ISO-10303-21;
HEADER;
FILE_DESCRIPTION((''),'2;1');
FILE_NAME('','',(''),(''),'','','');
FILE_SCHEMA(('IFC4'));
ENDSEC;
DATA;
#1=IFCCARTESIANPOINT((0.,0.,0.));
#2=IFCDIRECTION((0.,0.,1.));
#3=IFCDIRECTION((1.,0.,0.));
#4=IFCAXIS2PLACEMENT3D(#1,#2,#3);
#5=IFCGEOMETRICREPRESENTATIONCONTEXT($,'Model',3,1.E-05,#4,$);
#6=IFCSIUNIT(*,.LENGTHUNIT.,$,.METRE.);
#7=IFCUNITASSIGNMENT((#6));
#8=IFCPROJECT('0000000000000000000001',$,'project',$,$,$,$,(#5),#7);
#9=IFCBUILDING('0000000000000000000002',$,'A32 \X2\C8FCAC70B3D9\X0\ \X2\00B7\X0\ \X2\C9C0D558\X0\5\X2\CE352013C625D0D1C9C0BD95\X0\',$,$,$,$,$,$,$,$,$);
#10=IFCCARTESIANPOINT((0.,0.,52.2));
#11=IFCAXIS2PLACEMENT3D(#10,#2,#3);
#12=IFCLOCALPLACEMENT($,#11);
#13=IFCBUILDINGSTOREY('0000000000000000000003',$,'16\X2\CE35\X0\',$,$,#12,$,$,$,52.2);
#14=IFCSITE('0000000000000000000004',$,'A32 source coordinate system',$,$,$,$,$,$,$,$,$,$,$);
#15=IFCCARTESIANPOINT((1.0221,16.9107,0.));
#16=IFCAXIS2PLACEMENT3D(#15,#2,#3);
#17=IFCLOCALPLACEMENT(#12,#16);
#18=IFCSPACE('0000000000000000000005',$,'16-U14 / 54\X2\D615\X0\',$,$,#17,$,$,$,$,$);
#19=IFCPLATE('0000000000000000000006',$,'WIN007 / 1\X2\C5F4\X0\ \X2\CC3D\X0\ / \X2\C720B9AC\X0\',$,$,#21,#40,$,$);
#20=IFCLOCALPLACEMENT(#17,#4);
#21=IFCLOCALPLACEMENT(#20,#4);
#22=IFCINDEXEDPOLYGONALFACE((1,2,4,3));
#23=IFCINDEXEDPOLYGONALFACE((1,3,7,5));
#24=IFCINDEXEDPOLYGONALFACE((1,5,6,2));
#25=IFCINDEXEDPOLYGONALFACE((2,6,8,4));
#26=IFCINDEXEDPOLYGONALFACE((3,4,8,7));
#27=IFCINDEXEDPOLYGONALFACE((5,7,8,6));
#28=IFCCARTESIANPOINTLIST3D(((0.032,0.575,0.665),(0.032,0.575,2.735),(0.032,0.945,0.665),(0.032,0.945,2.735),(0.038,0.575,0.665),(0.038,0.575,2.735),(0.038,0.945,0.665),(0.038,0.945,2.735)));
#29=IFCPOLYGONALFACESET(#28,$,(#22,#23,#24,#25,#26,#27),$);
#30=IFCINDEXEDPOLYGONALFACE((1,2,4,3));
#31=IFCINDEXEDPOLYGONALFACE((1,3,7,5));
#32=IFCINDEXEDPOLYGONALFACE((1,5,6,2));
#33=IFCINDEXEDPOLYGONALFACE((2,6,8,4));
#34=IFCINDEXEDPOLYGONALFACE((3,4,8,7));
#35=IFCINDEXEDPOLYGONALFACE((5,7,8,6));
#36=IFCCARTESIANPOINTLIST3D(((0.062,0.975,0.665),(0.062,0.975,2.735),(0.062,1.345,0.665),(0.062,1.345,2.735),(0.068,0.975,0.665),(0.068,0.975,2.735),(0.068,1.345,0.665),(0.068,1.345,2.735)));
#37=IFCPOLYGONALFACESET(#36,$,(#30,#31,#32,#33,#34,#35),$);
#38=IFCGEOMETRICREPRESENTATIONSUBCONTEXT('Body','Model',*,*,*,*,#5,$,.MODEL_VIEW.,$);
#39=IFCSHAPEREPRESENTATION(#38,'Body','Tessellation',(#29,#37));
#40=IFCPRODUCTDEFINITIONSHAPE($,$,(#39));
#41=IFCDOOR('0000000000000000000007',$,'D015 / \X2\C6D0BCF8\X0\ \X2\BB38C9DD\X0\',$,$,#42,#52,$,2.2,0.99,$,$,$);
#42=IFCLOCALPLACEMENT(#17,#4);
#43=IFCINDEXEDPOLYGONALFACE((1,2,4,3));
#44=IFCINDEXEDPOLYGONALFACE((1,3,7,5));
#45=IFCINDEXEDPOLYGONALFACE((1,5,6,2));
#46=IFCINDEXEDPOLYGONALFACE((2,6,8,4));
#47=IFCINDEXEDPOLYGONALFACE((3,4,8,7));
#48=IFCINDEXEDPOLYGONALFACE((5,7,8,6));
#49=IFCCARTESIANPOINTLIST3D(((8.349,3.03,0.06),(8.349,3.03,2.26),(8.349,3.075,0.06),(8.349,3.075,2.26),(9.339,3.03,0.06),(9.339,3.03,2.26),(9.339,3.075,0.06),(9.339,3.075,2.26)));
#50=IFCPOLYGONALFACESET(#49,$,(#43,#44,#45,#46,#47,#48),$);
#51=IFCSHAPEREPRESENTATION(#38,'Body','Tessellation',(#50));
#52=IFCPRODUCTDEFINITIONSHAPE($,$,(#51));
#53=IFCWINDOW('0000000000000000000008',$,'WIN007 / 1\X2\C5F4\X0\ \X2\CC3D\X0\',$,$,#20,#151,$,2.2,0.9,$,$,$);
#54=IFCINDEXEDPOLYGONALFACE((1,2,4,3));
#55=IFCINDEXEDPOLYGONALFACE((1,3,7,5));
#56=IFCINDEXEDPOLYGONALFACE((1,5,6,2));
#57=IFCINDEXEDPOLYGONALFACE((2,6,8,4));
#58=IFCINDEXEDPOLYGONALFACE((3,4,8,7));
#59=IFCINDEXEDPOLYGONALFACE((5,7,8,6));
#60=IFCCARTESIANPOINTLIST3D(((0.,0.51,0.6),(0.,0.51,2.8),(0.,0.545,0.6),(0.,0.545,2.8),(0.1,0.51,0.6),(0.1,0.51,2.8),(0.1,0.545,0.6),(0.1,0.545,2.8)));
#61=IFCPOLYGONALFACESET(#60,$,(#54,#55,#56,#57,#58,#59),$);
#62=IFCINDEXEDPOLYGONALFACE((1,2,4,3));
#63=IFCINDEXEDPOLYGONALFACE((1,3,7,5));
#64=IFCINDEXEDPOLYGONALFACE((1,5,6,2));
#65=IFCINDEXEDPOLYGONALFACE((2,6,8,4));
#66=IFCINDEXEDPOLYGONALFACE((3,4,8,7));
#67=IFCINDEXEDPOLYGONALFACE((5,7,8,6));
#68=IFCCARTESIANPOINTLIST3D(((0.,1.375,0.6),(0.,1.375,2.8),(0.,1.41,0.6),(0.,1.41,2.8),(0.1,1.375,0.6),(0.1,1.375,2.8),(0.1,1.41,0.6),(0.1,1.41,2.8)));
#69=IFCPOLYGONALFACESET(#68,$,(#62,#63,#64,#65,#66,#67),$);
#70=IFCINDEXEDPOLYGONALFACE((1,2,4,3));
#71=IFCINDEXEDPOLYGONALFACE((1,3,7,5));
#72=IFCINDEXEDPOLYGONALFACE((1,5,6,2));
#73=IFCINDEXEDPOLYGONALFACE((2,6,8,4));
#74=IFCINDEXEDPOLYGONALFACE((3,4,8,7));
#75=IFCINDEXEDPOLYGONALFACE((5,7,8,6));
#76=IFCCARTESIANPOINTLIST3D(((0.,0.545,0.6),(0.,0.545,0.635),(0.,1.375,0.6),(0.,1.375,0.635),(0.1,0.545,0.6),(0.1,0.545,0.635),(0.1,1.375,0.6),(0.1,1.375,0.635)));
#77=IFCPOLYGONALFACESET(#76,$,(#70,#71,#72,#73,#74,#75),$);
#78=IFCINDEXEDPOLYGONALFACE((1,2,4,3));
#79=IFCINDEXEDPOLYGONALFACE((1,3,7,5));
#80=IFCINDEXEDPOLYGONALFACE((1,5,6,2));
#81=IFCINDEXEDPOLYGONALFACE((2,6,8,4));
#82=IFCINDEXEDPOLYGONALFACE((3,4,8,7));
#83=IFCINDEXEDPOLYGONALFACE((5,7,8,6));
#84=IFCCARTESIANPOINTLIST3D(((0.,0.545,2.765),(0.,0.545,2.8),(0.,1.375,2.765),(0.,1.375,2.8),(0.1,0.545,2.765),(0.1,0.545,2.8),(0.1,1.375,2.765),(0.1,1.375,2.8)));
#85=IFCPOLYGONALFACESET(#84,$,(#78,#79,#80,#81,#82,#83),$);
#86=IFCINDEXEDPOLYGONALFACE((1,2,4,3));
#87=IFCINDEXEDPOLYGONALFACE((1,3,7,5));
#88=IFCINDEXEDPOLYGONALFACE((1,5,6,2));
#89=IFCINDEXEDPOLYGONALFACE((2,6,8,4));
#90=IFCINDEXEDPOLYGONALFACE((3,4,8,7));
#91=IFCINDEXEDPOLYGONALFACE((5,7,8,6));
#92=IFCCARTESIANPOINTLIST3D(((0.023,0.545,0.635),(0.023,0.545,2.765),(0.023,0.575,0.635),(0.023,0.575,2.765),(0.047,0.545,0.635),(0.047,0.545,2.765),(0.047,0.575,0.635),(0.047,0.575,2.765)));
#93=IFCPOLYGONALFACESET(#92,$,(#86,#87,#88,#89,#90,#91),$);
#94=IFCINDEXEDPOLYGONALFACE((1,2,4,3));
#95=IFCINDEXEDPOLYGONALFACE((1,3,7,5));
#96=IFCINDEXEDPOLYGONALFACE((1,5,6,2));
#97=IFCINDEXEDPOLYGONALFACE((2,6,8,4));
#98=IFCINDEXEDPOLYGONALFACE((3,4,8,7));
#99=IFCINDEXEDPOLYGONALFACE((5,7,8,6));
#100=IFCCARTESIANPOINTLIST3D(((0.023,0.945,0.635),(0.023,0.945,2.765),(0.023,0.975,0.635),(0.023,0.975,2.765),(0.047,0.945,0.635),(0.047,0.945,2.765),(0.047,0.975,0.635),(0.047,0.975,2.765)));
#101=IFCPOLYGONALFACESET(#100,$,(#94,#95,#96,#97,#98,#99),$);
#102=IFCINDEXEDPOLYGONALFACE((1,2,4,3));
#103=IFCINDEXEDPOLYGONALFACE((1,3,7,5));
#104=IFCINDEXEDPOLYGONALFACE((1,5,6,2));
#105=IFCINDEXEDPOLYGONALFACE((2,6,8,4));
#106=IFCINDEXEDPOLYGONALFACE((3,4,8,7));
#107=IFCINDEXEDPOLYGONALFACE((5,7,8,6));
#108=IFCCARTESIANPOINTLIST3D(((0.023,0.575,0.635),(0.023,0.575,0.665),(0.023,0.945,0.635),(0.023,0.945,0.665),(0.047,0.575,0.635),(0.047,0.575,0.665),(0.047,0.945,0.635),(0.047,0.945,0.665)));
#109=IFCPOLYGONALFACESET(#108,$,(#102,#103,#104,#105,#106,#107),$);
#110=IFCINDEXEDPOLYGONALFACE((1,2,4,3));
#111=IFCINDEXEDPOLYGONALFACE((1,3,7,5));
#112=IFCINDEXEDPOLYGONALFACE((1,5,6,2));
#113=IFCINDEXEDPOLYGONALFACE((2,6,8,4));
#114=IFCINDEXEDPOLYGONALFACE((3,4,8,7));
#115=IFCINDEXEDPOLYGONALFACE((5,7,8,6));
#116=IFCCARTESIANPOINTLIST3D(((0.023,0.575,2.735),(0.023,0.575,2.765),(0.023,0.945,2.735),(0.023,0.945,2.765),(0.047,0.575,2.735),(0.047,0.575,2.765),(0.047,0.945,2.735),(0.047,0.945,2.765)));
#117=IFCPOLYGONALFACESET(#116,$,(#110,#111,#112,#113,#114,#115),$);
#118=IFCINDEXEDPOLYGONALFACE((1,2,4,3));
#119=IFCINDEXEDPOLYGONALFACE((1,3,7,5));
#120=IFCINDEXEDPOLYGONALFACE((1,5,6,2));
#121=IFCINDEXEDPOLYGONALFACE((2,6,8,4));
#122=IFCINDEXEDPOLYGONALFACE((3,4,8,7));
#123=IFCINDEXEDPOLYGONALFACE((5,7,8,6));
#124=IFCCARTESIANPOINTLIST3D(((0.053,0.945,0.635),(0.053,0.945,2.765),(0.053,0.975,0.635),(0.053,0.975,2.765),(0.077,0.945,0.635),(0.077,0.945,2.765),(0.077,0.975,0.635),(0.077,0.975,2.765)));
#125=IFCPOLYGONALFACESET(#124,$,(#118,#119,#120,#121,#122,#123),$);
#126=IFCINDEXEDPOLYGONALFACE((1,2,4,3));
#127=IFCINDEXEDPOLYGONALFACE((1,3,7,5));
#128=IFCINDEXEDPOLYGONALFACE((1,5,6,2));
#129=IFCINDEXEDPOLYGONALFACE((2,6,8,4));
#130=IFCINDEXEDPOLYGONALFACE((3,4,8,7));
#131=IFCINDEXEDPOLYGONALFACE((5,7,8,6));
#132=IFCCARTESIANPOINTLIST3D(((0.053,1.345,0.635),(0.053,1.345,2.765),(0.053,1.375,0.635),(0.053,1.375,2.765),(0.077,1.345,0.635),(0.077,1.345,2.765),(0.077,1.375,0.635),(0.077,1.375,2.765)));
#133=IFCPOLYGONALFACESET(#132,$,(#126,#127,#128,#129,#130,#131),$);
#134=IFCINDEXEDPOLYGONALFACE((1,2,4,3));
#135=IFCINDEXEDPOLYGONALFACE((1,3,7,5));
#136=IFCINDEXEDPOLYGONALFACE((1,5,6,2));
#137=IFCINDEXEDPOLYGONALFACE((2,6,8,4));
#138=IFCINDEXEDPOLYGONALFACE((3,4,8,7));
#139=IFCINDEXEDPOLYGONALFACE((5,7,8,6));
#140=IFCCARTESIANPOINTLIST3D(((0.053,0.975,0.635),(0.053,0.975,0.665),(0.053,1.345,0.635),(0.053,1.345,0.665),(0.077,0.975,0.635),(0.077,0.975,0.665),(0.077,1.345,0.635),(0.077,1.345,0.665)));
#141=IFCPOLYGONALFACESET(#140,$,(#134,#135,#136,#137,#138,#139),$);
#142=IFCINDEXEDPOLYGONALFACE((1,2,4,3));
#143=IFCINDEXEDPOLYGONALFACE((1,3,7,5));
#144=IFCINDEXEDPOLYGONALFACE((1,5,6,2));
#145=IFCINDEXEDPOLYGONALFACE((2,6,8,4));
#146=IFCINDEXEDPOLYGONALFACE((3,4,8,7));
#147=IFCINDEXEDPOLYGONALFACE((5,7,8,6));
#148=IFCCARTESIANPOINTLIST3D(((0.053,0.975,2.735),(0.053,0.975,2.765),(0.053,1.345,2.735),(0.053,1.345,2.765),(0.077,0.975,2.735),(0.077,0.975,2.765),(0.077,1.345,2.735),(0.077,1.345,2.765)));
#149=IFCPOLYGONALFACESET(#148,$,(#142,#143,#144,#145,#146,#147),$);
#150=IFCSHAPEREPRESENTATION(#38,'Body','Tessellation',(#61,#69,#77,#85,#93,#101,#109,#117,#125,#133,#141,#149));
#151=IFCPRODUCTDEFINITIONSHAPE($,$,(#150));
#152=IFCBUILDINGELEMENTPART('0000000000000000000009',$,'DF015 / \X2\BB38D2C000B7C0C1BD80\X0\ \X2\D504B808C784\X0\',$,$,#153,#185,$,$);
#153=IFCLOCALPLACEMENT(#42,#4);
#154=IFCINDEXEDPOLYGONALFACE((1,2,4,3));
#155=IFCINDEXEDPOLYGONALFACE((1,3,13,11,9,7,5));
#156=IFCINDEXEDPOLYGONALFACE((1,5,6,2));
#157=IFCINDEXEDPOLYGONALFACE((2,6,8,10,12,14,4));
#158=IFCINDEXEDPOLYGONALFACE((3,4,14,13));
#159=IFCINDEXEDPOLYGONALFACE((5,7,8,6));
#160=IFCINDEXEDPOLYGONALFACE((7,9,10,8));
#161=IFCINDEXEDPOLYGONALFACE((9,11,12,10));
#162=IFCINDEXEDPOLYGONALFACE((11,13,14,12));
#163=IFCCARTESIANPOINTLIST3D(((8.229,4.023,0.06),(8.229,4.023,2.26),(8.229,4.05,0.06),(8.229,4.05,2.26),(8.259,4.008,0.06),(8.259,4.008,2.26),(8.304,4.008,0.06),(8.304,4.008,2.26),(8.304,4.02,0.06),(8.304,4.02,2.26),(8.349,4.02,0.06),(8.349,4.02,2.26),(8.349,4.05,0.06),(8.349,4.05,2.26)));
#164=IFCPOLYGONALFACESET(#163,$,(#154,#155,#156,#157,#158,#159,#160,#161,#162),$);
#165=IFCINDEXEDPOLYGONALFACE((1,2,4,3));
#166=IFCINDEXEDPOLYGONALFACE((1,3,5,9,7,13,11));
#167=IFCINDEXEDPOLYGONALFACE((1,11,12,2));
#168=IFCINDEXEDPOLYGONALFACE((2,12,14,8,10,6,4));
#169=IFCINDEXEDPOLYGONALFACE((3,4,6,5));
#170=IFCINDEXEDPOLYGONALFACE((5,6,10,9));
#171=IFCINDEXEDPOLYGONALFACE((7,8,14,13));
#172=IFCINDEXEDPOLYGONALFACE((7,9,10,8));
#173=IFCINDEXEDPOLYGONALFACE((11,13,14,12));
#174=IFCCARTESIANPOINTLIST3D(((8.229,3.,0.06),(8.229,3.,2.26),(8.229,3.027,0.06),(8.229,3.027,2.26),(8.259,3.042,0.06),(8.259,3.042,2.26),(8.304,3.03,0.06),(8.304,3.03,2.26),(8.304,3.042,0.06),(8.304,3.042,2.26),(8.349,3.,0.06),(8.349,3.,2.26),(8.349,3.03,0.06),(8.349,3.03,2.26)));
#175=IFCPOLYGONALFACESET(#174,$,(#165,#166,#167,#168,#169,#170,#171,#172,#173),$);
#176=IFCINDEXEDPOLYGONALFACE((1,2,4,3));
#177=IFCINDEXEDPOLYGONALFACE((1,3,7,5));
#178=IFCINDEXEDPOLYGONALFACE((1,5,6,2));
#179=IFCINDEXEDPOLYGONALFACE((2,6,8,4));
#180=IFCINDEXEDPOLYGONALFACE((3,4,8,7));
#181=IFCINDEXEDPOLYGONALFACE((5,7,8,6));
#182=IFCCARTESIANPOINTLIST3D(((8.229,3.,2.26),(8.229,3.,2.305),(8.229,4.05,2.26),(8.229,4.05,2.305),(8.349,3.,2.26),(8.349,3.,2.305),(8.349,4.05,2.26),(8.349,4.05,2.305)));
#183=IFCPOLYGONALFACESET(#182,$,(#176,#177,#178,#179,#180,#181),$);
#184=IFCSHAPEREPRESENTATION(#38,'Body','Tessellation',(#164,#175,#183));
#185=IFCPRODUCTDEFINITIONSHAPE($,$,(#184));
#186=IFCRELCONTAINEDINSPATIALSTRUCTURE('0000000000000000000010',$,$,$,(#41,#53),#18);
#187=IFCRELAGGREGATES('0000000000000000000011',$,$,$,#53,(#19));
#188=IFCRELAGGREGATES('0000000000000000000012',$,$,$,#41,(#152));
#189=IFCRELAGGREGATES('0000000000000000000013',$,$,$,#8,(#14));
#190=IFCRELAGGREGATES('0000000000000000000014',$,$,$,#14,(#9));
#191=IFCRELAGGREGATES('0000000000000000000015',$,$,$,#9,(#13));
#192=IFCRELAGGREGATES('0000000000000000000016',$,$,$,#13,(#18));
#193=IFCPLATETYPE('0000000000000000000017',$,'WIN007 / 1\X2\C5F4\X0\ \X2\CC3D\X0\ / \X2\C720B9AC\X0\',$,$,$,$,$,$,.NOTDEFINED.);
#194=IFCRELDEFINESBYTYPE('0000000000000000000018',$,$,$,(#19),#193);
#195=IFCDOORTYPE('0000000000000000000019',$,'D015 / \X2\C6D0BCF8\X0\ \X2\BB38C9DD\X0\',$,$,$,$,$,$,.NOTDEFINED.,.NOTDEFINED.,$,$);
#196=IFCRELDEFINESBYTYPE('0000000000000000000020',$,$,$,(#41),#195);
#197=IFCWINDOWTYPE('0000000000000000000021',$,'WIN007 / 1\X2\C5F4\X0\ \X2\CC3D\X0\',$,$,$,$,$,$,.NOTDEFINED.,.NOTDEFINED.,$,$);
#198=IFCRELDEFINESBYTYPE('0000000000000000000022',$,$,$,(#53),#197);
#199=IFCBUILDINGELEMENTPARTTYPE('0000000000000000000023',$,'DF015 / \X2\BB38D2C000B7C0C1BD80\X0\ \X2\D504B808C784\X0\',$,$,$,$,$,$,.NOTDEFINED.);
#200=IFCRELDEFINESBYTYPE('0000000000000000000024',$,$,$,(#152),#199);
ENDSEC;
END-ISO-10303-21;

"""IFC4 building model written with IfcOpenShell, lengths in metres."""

from ifc_helpers import new_model, si_unit, frame, origin, origin_with_axes, place, context, subcontext, project, spatial, polyline, outline, extrude, source, transform, mapped, type_object, type_shapes, element, aggregate, save


model = new_model("IFC4")

# Units and contexts
model_context = context("Model", 3, precision=1e-05, world=origin_with_axes())
body_context = subcontext(model_context, "Body", "Model", "MODEL_VIEW")
ifc_project = project(units=[si_unit("LENGTHUNIT", "METRE")], contexts=[model_context])

# Plate
plate_type_1 = type_object("IfcPlateType", Name="WIN007 / 1열 창 / 유리", PredefinedType="NOTDEFINED")
shared_shape_1 = source(origin(), body_context, "Body", "SweptSolid", [
    extrude(outline(polyline([(0.032, 0.575), (0.032, 0.945), (0.038, 0.945), (0.038, 0.575), (0.032, 0.575)])), frame((0.0, 0.0, 0.665)), (0.0, 0.0, 1.0), 2.07),
    extrude(outline(polyline([(0.062, 0.975), (0.062, 1.345), (0.068, 1.345), (0.068, 0.975), (0.062, 0.975)])), frame((0.0, 0.0, 0.665)), (0.0, 0.0, 1.0), 2.07),
])
type_shapes(plate_type_1, [shared_shape_1])
storey_placement = place(None, frame((0.0, 0.0, 52.2), z_axis=(0.0, 0.0, 1.0), x_axis=(1.0, 0.0, 0.0)))
space_1_placement = place(storey_placement, frame((1.0221, 16.9107, 0.0), z_axis=(0.0, 0.0, 1.0), x_axis=(1.0, 0.0, 0.0)))
window_1_placement = place(space_1_placement, origin_with_axes())
plate_1_placement = place(window_1_placement, origin_with_axes())
plate_1 = element("IfcPlate", 1, at=plate_1_placement, type_object=plate_type_1, Name="WIN007 / 1열 창 / 유리", context=body_context, shape_type="MappedRepresentation", body=[
    mapped(shared_shape_1, transform((0.0, 0.0, 0.0), scale=1.0)),
])

# Site, building, storey, space
site = spatial("IfcSite", under=ifc_project, Name="A32 source coordinate system")
building = spatial("IfcBuilding", under=site, Name="A32 주거동 · 지하5층–옥탑지붕")
storey = spatial("IfcBuildingStorey", under=building, at=storey_placement, Name="16층", Elevation=52.2)
space_1 = spatial("IfcSpace", under=storey, at=space_1_placement, Name="16-U14 / 54형")

# Door
door_type_1 = type_object("IfcDoorType", Name="D015 / 원본 문짝", OperationType="NOTDEFINED", PredefinedType="NOTDEFINED")
shared_shape_2 = source(origin(), body_context, "Body", "SweptSolid", [
    extrude(outline(polyline([(9.339, 3.075), (9.339, 3.03), (8.349, 3.03), (8.349, 3.075), (9.339, 3.075)])), frame((0.0, 0.0, 0.06)), (0.0, 0.0, 1.0), 2.2),
])
type_shapes(door_type_1, [shared_shape_2])
door_1_placement = place(space_1_placement, origin_with_axes())
door_1 = element("IfcDoor", 2, at=door_1_placement, inside=space_1, type_object=door_type_1, Name="D015 / 원본 문짝", OverallHeight=2.2, OverallWidth=0.99, context=body_context, shape_type="MappedRepresentation", body=[
    mapped(shared_shape_2, transform((0.0, 0.0, 0.0), scale=1.0)),
])

# Window
window_type_1 = type_object("IfcWindowType", Name="WIN007 / 1열 창", PartitioningType="NOTDEFINED", PredefinedType="NOTDEFINED")
shared_shape_3 = source(origin(), body_context, "Body", "SweptSolid", [
    extrude(outline(polyline([(0.0, 0.51), (0.0, 0.545), (0.1, 0.545), (0.1, 0.51), (0.0, 0.51)])), frame((0.0, 0.0, 0.6)), (0.0, 0.0, 1.0), 2.2),
    extrude(outline(polyline([(0.0, 1.375), (0.0, 1.41), (0.1, 1.41), (0.1, 1.375), (0.0, 1.375)])), frame((0.0, 0.0, 0.6)), (0.0, 0.0, 1.0), 2.2),
    extrude(outline(polyline([(0.0, 0.545), (0.0, 1.375), (0.1, 1.375), (0.1, 0.545), (0.0, 0.545)])), frame((0.0, 0.0, 0.6)), (0.0, 0.0, 1.0), 0.035),
    extrude(outline(polyline([(0.0, 0.545), (0.0, 1.375), (0.1, 1.375), (0.1, 0.545), (0.0, 0.545)])), frame((0.0, 0.0, 2.765)), (0.0, 0.0, 1.0), 0.035),
    extrude(outline(polyline([(0.023, 0.545), (0.023, 0.575), (0.047, 0.575), (0.047, 0.545), (0.023, 0.545)])), frame((0.0, 0.0, 0.635)), (0.0, 0.0, 1.0), 2.13),
    extrude(outline(polyline([(0.023, 0.945), (0.023, 0.975), (0.047, 0.975), (0.047, 0.945), (0.023, 0.945)])), frame((0.0, 0.0, 0.635)), (0.0, 0.0, 1.0), 2.13),
    extrude(outline(polyline([(0.023, 0.575), (0.023, 0.945), (0.047, 0.945), (0.047, 0.575), (0.023, 0.575)])), frame((0.0, 0.0, 0.635)), (0.0, 0.0, 1.0), 0.03),
    extrude(outline(polyline([(0.023, 0.575), (0.023, 0.945), (0.047, 0.945), (0.047, 0.575), (0.023, 0.575)])), frame((0.0, 0.0, 2.735)), (0.0, 0.0, 1.0), 0.03),
    extrude(outline(polyline([(0.053, 0.945), (0.053, 0.975), (0.077, 0.975), (0.077, 0.945), (0.053, 0.945)])), frame((0.0, 0.0, 0.635)), (0.0, 0.0, 1.0), 2.13),
    extrude(outline(polyline([(0.053, 1.345), (0.053, 1.375), (0.077, 1.375), (0.077, 1.345), (0.053, 1.345)])), frame((0.0, 0.0, 0.635)), (0.0, 0.0, 1.0), 2.13),
    extrude(outline(polyline([(0.053, 0.975), (0.053, 1.345), (0.077, 1.345), (0.077, 0.975), (0.053, 0.975)])), frame((0.0, 0.0, 0.635)), (0.0, 0.0, 1.0), 0.03),
    extrude(outline(polyline([(0.053, 0.975), (0.053, 1.345), (0.077, 1.345), (0.077, 0.975), (0.053, 0.975)])), frame((0.0, 0.0, 2.735)), (0.0, 0.0, 1.0), 0.03),
])
type_shapes(window_type_1, [shared_shape_3])
window_1 = element("IfcWindow", 3, at=window_1_placement, inside=space_1, type_object=window_type_1, Name="WIN007 / 1열 창", OverallHeight=2.2, OverallWidth=0.9, context=body_context, shape_type="MappedRepresentation", body=[
    mapped(shared_shape_3, transform((0.0, 0.0, 0.0), scale=1.0)),
])
aggregate(window_1, [plate_1])

# Building element part
building_element_part_type_1 = type_object("IfcBuildingElementPartType", Name="DF015 / 문틀·상부 프레임", PredefinedType="NOTDEFINED")
shared_shape_4 = source(origin(), body_context, "Body", "SweptSolid", [
    extrude(outline(polyline([(8.349, 4.02), (8.304, 4.02), (8.304, 4.008), (8.259, 4.008), (8.229, 4.023), (8.229, 4.05), (8.349, 4.05), (8.349, 4.02)])), frame((0.0, 0.0, 0.06)), (0.0, 0.0, 1.0), 2.2),
    extrude(outline(polyline([(8.229, 3.0), (8.229, 3.027), (8.259, 3.042), (8.304, 3.042), (8.304, 3.03), (8.349, 3.03), (8.349, 3.0), (8.229, 3.0)])), frame((0.0, 0.0, 0.06)), (0.0, 0.0, 1.0), 2.2),
    extrude(outline(polyline([(8.229, 3.0), (8.229, 4.05), (8.349, 4.05), (8.349, 3.0), (8.229, 3.0)])), frame((0.0, 0.0, 2.26)), (0.0, 0.0, 1.0), 0.045),
])
type_shapes(building_element_part_type_1, [shared_shape_4])
building_element_part_1_placement = place(door_1_placement, origin_with_axes())
building_element_part_1 = element("IfcBuildingElementPart", 4, at=building_element_part_1_placement, type_object=building_element_part_type_1, Name="DF015 / 문틀·상부 프레임", context=body_context, shape_type="MappedRepresentation", body=[
    mapped(shared_shape_4, transform((0.0, 0.0, 0.0), scale=1.0)),
])
aggregate(door_1, [building_element_part_1])

save(model, "model.ifc")
